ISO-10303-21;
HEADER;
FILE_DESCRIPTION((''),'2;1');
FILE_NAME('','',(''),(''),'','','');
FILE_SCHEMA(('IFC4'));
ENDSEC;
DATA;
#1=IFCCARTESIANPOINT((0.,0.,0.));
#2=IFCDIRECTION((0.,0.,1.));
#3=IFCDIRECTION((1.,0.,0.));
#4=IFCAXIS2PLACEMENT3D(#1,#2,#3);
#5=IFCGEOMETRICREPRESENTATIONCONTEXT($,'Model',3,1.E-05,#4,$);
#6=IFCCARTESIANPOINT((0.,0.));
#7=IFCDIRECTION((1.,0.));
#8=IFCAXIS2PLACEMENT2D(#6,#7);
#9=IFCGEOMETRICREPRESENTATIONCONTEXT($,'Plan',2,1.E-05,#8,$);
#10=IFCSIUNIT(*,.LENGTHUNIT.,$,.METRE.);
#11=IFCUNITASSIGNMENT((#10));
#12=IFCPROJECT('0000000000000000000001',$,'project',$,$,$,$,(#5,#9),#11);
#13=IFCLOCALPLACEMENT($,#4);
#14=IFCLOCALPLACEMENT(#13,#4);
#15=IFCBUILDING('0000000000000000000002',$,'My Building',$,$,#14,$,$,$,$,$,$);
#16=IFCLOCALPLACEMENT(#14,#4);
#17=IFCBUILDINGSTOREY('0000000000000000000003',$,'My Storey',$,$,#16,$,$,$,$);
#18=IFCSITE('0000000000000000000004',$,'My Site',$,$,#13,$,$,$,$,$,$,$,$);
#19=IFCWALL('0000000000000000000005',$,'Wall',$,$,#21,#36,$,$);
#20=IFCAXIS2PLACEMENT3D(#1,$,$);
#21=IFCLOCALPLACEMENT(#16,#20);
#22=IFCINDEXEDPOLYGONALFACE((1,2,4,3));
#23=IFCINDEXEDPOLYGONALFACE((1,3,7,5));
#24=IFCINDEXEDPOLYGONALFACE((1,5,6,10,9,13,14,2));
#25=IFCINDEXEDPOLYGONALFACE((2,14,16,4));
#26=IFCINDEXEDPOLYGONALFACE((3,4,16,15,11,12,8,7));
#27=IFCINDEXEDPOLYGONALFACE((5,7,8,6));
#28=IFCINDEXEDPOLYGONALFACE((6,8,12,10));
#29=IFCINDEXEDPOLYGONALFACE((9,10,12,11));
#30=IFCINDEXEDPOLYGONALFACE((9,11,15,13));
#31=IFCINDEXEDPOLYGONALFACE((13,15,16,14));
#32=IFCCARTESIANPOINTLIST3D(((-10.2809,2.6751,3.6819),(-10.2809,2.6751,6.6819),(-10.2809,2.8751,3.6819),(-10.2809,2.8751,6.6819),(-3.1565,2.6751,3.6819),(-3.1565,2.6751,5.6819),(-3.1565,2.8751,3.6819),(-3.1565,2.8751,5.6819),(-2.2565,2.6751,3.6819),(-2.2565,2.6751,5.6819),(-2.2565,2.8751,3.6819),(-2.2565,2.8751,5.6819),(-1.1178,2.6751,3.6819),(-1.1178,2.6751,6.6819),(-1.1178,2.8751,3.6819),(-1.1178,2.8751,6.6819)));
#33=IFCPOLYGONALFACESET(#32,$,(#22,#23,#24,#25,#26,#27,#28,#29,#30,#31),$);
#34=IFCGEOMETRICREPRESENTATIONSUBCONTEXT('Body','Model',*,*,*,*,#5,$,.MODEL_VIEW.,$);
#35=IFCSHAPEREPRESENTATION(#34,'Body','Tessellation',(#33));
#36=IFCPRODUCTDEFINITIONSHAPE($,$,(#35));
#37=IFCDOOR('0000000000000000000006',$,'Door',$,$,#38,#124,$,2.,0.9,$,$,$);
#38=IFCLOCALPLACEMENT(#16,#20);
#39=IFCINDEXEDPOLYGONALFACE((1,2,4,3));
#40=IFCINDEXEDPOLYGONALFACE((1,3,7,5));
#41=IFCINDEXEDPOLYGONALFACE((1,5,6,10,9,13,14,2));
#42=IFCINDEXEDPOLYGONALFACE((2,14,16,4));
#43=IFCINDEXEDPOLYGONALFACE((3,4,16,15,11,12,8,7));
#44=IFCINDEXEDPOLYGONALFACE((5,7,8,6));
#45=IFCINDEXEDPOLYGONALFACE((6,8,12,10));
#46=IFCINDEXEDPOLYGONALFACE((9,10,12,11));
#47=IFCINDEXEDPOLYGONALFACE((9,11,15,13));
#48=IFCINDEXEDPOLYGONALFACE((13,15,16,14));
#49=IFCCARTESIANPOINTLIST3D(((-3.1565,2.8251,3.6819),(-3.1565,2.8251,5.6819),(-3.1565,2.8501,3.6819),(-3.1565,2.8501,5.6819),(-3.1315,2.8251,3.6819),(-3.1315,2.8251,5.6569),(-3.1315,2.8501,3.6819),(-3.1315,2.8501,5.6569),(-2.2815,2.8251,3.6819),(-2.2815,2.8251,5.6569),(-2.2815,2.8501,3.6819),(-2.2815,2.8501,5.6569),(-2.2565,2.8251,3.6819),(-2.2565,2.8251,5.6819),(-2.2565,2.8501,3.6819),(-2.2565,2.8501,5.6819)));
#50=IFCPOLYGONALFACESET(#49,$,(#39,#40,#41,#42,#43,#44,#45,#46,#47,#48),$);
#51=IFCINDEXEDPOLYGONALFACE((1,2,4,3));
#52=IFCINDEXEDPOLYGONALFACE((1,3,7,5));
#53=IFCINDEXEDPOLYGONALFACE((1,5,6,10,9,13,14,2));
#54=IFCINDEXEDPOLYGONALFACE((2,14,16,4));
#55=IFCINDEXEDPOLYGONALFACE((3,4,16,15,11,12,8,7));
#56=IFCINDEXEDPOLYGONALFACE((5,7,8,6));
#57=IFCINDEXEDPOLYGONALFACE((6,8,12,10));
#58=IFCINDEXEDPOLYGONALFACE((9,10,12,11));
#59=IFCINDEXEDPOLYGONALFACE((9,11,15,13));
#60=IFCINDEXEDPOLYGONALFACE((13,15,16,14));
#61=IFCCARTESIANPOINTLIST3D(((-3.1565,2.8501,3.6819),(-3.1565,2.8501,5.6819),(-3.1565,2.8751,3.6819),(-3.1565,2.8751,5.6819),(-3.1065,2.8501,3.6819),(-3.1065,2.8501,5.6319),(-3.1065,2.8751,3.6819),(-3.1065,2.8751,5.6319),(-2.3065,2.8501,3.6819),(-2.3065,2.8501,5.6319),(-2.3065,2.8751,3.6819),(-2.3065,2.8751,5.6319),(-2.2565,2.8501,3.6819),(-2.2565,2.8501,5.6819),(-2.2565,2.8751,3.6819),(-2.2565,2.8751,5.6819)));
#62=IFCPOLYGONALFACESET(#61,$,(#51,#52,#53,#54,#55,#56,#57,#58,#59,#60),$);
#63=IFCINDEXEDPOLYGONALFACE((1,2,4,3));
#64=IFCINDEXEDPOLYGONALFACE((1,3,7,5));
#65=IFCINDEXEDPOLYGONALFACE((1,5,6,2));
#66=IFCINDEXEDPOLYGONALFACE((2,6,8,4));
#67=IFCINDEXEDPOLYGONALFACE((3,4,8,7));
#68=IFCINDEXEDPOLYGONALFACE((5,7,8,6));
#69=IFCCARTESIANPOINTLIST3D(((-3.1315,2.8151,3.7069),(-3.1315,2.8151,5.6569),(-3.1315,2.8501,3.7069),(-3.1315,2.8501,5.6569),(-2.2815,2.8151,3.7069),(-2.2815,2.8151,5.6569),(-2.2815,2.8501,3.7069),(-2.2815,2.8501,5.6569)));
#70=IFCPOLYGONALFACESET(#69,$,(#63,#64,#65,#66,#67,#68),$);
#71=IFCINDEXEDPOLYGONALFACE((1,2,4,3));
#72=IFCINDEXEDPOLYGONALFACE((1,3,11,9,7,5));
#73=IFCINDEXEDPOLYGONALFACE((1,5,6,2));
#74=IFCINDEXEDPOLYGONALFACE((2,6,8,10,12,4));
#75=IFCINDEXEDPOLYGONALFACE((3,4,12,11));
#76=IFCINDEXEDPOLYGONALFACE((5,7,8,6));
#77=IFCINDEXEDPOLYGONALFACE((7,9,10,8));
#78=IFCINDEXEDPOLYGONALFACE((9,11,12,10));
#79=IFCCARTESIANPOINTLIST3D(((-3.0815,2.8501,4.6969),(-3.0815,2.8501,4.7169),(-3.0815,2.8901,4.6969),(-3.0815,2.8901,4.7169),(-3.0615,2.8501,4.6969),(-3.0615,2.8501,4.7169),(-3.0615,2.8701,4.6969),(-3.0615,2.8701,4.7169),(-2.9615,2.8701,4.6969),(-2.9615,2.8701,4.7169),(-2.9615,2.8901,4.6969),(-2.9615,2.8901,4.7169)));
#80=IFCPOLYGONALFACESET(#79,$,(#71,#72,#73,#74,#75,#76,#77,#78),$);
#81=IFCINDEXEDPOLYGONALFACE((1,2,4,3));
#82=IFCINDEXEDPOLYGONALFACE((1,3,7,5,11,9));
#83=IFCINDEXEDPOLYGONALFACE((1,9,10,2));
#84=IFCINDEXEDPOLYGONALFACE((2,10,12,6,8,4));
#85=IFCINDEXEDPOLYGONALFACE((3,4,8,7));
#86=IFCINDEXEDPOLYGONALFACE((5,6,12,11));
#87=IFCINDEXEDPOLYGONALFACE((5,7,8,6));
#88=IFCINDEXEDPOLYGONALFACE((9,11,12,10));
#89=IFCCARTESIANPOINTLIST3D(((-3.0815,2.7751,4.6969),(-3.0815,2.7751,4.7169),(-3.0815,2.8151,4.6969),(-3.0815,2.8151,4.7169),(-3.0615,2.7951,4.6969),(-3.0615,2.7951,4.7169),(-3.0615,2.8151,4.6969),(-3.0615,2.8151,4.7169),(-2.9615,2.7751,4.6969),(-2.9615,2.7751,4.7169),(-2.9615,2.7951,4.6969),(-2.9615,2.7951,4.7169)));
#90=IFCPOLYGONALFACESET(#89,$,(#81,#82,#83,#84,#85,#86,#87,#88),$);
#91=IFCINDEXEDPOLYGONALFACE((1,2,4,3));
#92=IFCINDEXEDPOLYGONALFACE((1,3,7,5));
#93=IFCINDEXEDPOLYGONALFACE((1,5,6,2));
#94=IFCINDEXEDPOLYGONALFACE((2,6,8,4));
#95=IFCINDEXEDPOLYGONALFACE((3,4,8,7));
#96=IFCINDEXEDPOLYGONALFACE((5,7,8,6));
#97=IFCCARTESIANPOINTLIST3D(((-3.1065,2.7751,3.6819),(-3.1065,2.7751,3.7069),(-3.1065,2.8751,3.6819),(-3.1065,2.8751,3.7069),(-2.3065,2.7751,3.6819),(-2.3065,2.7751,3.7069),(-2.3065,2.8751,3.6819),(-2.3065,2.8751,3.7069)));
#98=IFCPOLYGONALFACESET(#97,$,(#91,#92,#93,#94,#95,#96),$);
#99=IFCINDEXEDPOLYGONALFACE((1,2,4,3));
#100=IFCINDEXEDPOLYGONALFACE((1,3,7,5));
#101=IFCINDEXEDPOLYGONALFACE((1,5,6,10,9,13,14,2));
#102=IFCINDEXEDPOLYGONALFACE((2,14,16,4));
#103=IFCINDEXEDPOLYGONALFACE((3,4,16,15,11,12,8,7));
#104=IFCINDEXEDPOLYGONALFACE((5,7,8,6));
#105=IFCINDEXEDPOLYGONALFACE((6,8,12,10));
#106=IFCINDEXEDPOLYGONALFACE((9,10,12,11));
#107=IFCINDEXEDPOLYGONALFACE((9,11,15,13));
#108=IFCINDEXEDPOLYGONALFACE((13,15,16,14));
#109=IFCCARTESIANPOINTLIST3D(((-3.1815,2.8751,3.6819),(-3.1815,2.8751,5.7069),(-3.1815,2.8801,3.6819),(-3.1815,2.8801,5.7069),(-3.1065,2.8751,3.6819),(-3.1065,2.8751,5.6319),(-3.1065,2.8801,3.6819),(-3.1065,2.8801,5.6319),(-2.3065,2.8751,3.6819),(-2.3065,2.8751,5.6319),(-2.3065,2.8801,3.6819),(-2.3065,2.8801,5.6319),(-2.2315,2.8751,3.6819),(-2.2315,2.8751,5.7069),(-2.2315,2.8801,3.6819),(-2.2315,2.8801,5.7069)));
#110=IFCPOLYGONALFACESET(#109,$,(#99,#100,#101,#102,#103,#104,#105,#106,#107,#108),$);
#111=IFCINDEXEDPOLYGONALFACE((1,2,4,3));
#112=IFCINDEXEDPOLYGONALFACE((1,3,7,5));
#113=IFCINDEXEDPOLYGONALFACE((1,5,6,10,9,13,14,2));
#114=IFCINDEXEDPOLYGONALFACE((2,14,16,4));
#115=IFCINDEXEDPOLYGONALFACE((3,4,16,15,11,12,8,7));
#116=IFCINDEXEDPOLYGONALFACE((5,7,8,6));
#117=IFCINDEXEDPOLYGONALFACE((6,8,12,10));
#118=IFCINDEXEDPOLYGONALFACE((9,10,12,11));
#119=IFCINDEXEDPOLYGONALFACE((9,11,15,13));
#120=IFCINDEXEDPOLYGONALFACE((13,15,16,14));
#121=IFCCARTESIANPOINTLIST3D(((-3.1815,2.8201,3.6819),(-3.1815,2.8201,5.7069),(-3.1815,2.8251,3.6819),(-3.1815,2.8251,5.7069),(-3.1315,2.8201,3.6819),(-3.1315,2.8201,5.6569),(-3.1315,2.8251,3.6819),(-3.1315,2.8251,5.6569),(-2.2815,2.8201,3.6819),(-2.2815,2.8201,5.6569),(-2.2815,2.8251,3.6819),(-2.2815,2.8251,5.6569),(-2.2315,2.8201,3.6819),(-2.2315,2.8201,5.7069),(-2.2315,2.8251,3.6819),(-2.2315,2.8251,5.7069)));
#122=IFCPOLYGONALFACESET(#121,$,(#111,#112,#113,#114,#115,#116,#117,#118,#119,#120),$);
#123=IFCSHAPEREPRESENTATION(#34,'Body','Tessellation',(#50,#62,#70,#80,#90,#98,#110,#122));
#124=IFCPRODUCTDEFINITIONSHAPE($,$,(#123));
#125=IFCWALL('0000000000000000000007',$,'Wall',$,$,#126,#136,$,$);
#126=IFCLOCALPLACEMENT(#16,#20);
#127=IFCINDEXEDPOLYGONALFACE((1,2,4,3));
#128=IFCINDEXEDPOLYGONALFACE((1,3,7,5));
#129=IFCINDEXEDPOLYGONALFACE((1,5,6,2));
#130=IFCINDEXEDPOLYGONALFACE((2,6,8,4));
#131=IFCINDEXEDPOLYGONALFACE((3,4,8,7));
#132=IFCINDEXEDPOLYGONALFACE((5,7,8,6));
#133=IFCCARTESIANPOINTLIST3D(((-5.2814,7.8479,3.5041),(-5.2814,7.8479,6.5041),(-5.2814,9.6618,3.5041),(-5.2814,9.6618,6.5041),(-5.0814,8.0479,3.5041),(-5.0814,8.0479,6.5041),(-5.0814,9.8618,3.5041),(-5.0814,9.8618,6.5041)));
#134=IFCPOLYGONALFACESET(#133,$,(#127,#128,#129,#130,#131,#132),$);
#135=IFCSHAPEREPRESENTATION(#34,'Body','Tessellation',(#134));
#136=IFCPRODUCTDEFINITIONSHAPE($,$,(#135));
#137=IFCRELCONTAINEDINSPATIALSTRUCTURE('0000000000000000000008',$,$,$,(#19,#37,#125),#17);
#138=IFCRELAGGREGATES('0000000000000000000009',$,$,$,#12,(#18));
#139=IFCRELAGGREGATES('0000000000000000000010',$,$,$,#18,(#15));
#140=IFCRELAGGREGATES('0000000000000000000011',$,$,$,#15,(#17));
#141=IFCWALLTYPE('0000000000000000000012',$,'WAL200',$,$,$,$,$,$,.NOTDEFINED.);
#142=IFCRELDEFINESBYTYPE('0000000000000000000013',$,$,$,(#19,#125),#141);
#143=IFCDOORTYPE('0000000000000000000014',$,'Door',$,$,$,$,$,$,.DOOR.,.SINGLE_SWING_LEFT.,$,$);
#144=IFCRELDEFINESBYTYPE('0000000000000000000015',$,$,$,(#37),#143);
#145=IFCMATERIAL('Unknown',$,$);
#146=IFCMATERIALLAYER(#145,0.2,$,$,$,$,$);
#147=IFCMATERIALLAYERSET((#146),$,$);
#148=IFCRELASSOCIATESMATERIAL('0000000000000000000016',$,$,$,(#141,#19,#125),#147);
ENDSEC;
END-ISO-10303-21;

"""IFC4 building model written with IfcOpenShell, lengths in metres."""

from ifc_helpers import new_model, entity, si_unit, frame, origin_with_axes, origin_2d_with_axis, place, context, subcontext, project, spatial, line, indexed_curve, outline, extrude, shape, source, transform, mapped, material, layer, layer_set, layer_usage, type_object, type_shapes, element, fill, save


model = new_model("IFC4")

# Units and contexts
model_context = context("Model", 3, precision=1e-05, world=origin_with_axes())
plan_context = context("Plan", 2, precision=1e-05, world=origin_2d_with_axis())
body_context_1 = subcontext(model_context, "Body", "Model", "MODEL_VIEW")
body_context_2 = subcontext(plan_context, "Body", "Plan", "PLAN_VIEW")
ifc_project = project(units=[si_unit("LENGTHUNIT", "METRE")], contexts=[model_context, plan_context])

# Site, building, storey
site_placement = place(None, origin_with_axes())
site = spatial("IfcSite", under=ifc_project, at=site_placement, Name="My Site")
building_placement = place(site_placement, origin_with_axes())
building = spatial("IfcBuilding", under=site, at=building_placement, Name="My Building")
storey_placement = place(building_placement, origin_with_axes())
storey = spatial("IfcBuildingStorey", under=building, at=storey_placement, Name="My Storey")

# Shared definitions
ifc_material = material(Name="Unknown")

# Shared definitions
ifc_layer_1 = layer(ifc_material, 0.2)
ifc_layer_set_1 = layer_set([ifc_layer_1])
wall_type_1 = type_object("IfcWallType", Name="WAL200", PredefinedType="NOTDEFINED", material=ifc_layer_set_1)

# Shared definitions
shared_shape_1 = source(origin_with_axes(), body_context_1, "Body", "SweptSolid", [
    extrude(outline(indexed_curve([(0.0, 0.0), (0.9, 0.0), (0.9, 2.0), (0.0, 2.0)], segments=[line(1, 2, 3, 4, 1)])), frame((0.0, -0.6, 0.0), z_axis=(0.0, -1.0, 0.0), x_axis=(1.0, 0.0, 0.0)), (0.0, 0.0, -1.0), 1.2),
])
door_type = type_object("IfcDoorType", Name="Door", OperationType="SINGLE_SWING_LEFT", PredefinedType="DOOR")
shared_shape_2 = source(origin_with_axes(), body_context_1, "Body", "SweptSolid", [
    extrude(outline(indexed_curve([(0.0, 0.0), (0.0, 2.0), (0.9, 2.0), (0.9, 0.0), (0.875, 0.0), (0.875, 1.975), (0.025, 1.975), (0.025, 0.0)], segments=[line(1, 2, 3, 4, 5, 6, 7, 8, 1)])), frame((0.0, 0.025, 0.0), z_axis=(0.0, -1.0, 0.0), x_axis=(1.0, 0.0, 0.0)), (0.0, 0.0, -1.0), 0.025),
    extrude(outline(indexed_curve([(0.0, 0.0), (0.0, 2.0), (0.9, 2.0), (0.9, 0.0), (0.85, 0.0), (0.85, 1.95), (0.05, 1.95), (0.05, 0.0)], segments=[line(1, 2, 3, 4, 5, 6, 7, 8, 1)])), frame((0.0, 0.0, 0.0), z_axis=(0.0, -1.0, 0.0), x_axis=(1.0, 0.0, 0.0)), (0.0, 0.0, -1.0), 0.025),
    extrude(outline(indexed_curve([(0.0, 0.0), (0.85, 0.0), (0.85, 0.035), (0.0, 0.035)], segments=[line(1, 2, 3, 4, 1)])), frame((0.025, 0.025, 0.025), z_axis=(0.0, 0.0, 1.0), x_axis=(1.0, 0.0, 0.0)), (0.0, 0.0, 1.0), 1.95),
    extrude(outline(indexed_curve([(0.0, 0.0), (0.0, -0.04), (-0.12, -0.04), (-0.12, -0.02), (-0.02, -0.02), (-0.02, 0.0)], segments=[line(1, 2, 3, 4, 5, 6, 1)])), frame((0.825, 0.025, 1.015), z_axis=(0.0, 0.0, 1.0), x_axis=(1.0, 0.0, 0.0)), (0.0, 0.0, 1.0), 0.02),
    extrude(outline(indexed_curve([(0.0, 0.0), (0.0, 0.04), (-0.12, 0.04), (-0.12, 0.02), (-0.02, 0.02), (-0.02, 0.0)], segments=[line(1, 2, 3, 4, 5, 6, 1)])), frame((0.825, 0.06, 1.015), z_axis=(0.0, 0.0, 1.0), x_axis=(1.0, 0.0, 0.0)), (0.0, 0.0, 1.0), 0.02),
    extrude(outline(indexed_curve([(0.0, 0.0), (0.8, 0.0), (0.8, 0.1), (0.0, 0.1)], segments=[line(1, 2, 3, 4, 1)])), frame((0.05, 0.0, 0.0), z_axis=(0.0, 0.0, 1.0), x_axis=(1.0, 0.0, 0.0)), (0.0, 0.0, 1.0), 0.025),
    extrude(outline(indexed_curve([(0.0, 0.0), (0.0, 2.025), (0.95, 2.025), (0.95, 0.0), (0.875, 0.0), (0.875, 1.95), (0.075, 1.95), (0.075, 0.0)], segments=[line(1, 2, 3, 4, 5, 6, 7, 8, 1)])), frame((-0.025, -0.005, 0.0), z_axis=(0.0, -1.0, 0.0), x_axis=(1.0, 0.0, 0.0)), (0.0, 0.0, -1.0), 0.005),
    extrude(outline(indexed_curve([(0.0, 0.0), (0.0, 2.025), (0.95, 2.025), (0.95, 0.0), (0.9, 0.0), (0.9, 1.975), (0.05, 1.975), (0.05, 0.0)], segments=[line(1, 2, 3, 4, 5, 6, 7, 8, 1)])), frame((-0.025, 0.05, 0.0), z_axis=(0.0, -1.0, 0.0), x_axis=(1.0, 0.0, 0.0)), (0.0, 0.0, -1.0), 0.005),
])
shared_shape_3 = source(origin_with_axes(), body_context_2, "Body", "Curve2D", [
    entity("IfcIndexedPolyCurve", entity("IfcCartesianPointList2D", [[0.0, 0.0], [0.0, 0.05], [0.025, 0.05], [0.025, 0.025], [0.05, 0.025], [0.05, 0.0]]), [entity("IfcLineIndex", [1, 2, 3, 4, 5, 6, 1])]),
    entity("IfcIndexedPolyCurve", entity("IfcCartesianPointList2D", [[0.9, 0.0], [0.9, 0.05], [0.875, 0.05], [0.875, 0.025], [0.85, 0.025], [0.85, 0.0]]), [entity("IfcLineIndex", [1, 2, 3, 4, 5, 6, 1])]),
    entity("IfcTrimmedCurve", entity("IfcEllipse", entity("IfcAxis2Placement2D", entity("IfcCartesianPoint", [0.06, 0.05]), entity("IfcDirection", [1.0, 0.0])), 0.815, 0.85), [entity("IfcCartesianPoint", [0.875, 0.05])], [entity("IfcCartesianPoint", [0.06, 0.9])], True, "CARTESIAN"),
    entity("IfcIndexedPolyCurve", entity("IfcCartesianPointList2D", [[0.025, 0.05], [0.06, 0.05], [0.06, 0.9], [0.025, 0.9]]), [entity("IfcLineIndex", [1, 2, 3, 4, 1])]),
])
type_shapes(door_type, [shared_shape_2, shared_shape_3])

# Wall, opening, door
ifc_layer_usage_1 = layer_usage(ifc_layer_set_1, "AXIS2", "POSITIVE", 0.0)
wall_1_placement = place(storey_placement, frame((-10.2809, 2.6751, 3.6819), z_axis=(0.0, 0.0, 1.0), x_axis=(1.0, 0.0, 0.0)))
wall_1 = element("IfcWall", 1, at=wall_1_placement, inside=storey, type_object=wall_type_1, material=ifc_layer_usage_1, Name="Wall", context=body_context_1, shape_type="SweptSolid", body=[
    extrude(outline(indexed_curve([(0.0, 0.0), (0.0, 0.2), (9.1631, 0.2), (9.1631, 0.0)], segments=[line(1, 2, 3, 4, 1)])), origin_with_axes(), (0.0, 0.0, 1.0), 3.0),
])
opening_1_placement = place(wall_1_placement, frame((8.0244, 0.2, 0.0), z_axis=(0.0, 0.0, 1.0), x_axis=(-1.0, 0.0, 0.0)))
opening_1 = element("IfcOpeningElement", 2, at=opening_1_placement, cuts=wall_1, PredefinedType="OPENING", context=body_context_1, shape_type="MappedRepresentation", body=[
    mapped(shared_shape_1, transform((0.0, 0.0, 0.0), x_axis=(1.0, 0.0, 0.0), y_axis=(0.0, 1.0, 0.0), z_axis=(0.0, 0.0, 1.0), scale=1.0)),
])
door_1_placement = place(opening_1_placement, frame((0.0, 0.0, 0.0), z_axis=(0.0, 0.0, 1.0), x_axis=(1.0, 0.0, 0.0)))
door_1 = element("IfcDoor", 3, at=door_1_placement, inside=storey, type_object=door_type, Name="Door", OverallHeight=2.0, OverallWidth=0.9, shapes=[
    shape(body_context_1, "Body", "MappedRepresentation", [mapped(shared_shape_2, transform((0.0, 0.0, 0.0), x_axis=(1.0, 0.0, 0.0), y_axis=(0.0, 1.0, 0.0), z_axis=(0.0, 0.0, 1.0), scale=1.0))]),
    shape(body_context_2, "Body", "MappedRepresentation", [mapped(shared_shape_3, transform((0.0, 0.0, 0.0), x_axis=(1.0, 0.0, 0.0), y_axis=(0.0, 1.0, 0.0), z_axis=(0.0, 0.0, 1.0), scale=1.0))]),
])
fill(opening_1, door_1)

# Wall
ifc_layer_usage_2 = layer_usage(ifc_layer_set_1, "AXIS2", "POSITIVE", 0.0)
wall_2_placement = place(storey_placement, frame((-5.0814, 8.0479, 3.5041), z_axis=(0.0, 0.0, 1.0), x_axis=(0.0, 1.0, 0.0)))
element("IfcWall", 4, at=wall_2_placement, inside=storey, type_object=wall_type_1, material=ifc_layer_usage_2, Name="Wall", context=body_context_1, shape_type="SweptSolid", body=[
    extrude(outline(indexed_curve([(0.0, 0.0), (-0.2, 0.2), (1.6138, 0.2), (1.8138, 0.0)], segments=[line(1, 2, 3, 4, 1)])), origin_with_axes(), (0.0, 0.0, 1.0), 3.0),
])

save(model, "model.ifc")
